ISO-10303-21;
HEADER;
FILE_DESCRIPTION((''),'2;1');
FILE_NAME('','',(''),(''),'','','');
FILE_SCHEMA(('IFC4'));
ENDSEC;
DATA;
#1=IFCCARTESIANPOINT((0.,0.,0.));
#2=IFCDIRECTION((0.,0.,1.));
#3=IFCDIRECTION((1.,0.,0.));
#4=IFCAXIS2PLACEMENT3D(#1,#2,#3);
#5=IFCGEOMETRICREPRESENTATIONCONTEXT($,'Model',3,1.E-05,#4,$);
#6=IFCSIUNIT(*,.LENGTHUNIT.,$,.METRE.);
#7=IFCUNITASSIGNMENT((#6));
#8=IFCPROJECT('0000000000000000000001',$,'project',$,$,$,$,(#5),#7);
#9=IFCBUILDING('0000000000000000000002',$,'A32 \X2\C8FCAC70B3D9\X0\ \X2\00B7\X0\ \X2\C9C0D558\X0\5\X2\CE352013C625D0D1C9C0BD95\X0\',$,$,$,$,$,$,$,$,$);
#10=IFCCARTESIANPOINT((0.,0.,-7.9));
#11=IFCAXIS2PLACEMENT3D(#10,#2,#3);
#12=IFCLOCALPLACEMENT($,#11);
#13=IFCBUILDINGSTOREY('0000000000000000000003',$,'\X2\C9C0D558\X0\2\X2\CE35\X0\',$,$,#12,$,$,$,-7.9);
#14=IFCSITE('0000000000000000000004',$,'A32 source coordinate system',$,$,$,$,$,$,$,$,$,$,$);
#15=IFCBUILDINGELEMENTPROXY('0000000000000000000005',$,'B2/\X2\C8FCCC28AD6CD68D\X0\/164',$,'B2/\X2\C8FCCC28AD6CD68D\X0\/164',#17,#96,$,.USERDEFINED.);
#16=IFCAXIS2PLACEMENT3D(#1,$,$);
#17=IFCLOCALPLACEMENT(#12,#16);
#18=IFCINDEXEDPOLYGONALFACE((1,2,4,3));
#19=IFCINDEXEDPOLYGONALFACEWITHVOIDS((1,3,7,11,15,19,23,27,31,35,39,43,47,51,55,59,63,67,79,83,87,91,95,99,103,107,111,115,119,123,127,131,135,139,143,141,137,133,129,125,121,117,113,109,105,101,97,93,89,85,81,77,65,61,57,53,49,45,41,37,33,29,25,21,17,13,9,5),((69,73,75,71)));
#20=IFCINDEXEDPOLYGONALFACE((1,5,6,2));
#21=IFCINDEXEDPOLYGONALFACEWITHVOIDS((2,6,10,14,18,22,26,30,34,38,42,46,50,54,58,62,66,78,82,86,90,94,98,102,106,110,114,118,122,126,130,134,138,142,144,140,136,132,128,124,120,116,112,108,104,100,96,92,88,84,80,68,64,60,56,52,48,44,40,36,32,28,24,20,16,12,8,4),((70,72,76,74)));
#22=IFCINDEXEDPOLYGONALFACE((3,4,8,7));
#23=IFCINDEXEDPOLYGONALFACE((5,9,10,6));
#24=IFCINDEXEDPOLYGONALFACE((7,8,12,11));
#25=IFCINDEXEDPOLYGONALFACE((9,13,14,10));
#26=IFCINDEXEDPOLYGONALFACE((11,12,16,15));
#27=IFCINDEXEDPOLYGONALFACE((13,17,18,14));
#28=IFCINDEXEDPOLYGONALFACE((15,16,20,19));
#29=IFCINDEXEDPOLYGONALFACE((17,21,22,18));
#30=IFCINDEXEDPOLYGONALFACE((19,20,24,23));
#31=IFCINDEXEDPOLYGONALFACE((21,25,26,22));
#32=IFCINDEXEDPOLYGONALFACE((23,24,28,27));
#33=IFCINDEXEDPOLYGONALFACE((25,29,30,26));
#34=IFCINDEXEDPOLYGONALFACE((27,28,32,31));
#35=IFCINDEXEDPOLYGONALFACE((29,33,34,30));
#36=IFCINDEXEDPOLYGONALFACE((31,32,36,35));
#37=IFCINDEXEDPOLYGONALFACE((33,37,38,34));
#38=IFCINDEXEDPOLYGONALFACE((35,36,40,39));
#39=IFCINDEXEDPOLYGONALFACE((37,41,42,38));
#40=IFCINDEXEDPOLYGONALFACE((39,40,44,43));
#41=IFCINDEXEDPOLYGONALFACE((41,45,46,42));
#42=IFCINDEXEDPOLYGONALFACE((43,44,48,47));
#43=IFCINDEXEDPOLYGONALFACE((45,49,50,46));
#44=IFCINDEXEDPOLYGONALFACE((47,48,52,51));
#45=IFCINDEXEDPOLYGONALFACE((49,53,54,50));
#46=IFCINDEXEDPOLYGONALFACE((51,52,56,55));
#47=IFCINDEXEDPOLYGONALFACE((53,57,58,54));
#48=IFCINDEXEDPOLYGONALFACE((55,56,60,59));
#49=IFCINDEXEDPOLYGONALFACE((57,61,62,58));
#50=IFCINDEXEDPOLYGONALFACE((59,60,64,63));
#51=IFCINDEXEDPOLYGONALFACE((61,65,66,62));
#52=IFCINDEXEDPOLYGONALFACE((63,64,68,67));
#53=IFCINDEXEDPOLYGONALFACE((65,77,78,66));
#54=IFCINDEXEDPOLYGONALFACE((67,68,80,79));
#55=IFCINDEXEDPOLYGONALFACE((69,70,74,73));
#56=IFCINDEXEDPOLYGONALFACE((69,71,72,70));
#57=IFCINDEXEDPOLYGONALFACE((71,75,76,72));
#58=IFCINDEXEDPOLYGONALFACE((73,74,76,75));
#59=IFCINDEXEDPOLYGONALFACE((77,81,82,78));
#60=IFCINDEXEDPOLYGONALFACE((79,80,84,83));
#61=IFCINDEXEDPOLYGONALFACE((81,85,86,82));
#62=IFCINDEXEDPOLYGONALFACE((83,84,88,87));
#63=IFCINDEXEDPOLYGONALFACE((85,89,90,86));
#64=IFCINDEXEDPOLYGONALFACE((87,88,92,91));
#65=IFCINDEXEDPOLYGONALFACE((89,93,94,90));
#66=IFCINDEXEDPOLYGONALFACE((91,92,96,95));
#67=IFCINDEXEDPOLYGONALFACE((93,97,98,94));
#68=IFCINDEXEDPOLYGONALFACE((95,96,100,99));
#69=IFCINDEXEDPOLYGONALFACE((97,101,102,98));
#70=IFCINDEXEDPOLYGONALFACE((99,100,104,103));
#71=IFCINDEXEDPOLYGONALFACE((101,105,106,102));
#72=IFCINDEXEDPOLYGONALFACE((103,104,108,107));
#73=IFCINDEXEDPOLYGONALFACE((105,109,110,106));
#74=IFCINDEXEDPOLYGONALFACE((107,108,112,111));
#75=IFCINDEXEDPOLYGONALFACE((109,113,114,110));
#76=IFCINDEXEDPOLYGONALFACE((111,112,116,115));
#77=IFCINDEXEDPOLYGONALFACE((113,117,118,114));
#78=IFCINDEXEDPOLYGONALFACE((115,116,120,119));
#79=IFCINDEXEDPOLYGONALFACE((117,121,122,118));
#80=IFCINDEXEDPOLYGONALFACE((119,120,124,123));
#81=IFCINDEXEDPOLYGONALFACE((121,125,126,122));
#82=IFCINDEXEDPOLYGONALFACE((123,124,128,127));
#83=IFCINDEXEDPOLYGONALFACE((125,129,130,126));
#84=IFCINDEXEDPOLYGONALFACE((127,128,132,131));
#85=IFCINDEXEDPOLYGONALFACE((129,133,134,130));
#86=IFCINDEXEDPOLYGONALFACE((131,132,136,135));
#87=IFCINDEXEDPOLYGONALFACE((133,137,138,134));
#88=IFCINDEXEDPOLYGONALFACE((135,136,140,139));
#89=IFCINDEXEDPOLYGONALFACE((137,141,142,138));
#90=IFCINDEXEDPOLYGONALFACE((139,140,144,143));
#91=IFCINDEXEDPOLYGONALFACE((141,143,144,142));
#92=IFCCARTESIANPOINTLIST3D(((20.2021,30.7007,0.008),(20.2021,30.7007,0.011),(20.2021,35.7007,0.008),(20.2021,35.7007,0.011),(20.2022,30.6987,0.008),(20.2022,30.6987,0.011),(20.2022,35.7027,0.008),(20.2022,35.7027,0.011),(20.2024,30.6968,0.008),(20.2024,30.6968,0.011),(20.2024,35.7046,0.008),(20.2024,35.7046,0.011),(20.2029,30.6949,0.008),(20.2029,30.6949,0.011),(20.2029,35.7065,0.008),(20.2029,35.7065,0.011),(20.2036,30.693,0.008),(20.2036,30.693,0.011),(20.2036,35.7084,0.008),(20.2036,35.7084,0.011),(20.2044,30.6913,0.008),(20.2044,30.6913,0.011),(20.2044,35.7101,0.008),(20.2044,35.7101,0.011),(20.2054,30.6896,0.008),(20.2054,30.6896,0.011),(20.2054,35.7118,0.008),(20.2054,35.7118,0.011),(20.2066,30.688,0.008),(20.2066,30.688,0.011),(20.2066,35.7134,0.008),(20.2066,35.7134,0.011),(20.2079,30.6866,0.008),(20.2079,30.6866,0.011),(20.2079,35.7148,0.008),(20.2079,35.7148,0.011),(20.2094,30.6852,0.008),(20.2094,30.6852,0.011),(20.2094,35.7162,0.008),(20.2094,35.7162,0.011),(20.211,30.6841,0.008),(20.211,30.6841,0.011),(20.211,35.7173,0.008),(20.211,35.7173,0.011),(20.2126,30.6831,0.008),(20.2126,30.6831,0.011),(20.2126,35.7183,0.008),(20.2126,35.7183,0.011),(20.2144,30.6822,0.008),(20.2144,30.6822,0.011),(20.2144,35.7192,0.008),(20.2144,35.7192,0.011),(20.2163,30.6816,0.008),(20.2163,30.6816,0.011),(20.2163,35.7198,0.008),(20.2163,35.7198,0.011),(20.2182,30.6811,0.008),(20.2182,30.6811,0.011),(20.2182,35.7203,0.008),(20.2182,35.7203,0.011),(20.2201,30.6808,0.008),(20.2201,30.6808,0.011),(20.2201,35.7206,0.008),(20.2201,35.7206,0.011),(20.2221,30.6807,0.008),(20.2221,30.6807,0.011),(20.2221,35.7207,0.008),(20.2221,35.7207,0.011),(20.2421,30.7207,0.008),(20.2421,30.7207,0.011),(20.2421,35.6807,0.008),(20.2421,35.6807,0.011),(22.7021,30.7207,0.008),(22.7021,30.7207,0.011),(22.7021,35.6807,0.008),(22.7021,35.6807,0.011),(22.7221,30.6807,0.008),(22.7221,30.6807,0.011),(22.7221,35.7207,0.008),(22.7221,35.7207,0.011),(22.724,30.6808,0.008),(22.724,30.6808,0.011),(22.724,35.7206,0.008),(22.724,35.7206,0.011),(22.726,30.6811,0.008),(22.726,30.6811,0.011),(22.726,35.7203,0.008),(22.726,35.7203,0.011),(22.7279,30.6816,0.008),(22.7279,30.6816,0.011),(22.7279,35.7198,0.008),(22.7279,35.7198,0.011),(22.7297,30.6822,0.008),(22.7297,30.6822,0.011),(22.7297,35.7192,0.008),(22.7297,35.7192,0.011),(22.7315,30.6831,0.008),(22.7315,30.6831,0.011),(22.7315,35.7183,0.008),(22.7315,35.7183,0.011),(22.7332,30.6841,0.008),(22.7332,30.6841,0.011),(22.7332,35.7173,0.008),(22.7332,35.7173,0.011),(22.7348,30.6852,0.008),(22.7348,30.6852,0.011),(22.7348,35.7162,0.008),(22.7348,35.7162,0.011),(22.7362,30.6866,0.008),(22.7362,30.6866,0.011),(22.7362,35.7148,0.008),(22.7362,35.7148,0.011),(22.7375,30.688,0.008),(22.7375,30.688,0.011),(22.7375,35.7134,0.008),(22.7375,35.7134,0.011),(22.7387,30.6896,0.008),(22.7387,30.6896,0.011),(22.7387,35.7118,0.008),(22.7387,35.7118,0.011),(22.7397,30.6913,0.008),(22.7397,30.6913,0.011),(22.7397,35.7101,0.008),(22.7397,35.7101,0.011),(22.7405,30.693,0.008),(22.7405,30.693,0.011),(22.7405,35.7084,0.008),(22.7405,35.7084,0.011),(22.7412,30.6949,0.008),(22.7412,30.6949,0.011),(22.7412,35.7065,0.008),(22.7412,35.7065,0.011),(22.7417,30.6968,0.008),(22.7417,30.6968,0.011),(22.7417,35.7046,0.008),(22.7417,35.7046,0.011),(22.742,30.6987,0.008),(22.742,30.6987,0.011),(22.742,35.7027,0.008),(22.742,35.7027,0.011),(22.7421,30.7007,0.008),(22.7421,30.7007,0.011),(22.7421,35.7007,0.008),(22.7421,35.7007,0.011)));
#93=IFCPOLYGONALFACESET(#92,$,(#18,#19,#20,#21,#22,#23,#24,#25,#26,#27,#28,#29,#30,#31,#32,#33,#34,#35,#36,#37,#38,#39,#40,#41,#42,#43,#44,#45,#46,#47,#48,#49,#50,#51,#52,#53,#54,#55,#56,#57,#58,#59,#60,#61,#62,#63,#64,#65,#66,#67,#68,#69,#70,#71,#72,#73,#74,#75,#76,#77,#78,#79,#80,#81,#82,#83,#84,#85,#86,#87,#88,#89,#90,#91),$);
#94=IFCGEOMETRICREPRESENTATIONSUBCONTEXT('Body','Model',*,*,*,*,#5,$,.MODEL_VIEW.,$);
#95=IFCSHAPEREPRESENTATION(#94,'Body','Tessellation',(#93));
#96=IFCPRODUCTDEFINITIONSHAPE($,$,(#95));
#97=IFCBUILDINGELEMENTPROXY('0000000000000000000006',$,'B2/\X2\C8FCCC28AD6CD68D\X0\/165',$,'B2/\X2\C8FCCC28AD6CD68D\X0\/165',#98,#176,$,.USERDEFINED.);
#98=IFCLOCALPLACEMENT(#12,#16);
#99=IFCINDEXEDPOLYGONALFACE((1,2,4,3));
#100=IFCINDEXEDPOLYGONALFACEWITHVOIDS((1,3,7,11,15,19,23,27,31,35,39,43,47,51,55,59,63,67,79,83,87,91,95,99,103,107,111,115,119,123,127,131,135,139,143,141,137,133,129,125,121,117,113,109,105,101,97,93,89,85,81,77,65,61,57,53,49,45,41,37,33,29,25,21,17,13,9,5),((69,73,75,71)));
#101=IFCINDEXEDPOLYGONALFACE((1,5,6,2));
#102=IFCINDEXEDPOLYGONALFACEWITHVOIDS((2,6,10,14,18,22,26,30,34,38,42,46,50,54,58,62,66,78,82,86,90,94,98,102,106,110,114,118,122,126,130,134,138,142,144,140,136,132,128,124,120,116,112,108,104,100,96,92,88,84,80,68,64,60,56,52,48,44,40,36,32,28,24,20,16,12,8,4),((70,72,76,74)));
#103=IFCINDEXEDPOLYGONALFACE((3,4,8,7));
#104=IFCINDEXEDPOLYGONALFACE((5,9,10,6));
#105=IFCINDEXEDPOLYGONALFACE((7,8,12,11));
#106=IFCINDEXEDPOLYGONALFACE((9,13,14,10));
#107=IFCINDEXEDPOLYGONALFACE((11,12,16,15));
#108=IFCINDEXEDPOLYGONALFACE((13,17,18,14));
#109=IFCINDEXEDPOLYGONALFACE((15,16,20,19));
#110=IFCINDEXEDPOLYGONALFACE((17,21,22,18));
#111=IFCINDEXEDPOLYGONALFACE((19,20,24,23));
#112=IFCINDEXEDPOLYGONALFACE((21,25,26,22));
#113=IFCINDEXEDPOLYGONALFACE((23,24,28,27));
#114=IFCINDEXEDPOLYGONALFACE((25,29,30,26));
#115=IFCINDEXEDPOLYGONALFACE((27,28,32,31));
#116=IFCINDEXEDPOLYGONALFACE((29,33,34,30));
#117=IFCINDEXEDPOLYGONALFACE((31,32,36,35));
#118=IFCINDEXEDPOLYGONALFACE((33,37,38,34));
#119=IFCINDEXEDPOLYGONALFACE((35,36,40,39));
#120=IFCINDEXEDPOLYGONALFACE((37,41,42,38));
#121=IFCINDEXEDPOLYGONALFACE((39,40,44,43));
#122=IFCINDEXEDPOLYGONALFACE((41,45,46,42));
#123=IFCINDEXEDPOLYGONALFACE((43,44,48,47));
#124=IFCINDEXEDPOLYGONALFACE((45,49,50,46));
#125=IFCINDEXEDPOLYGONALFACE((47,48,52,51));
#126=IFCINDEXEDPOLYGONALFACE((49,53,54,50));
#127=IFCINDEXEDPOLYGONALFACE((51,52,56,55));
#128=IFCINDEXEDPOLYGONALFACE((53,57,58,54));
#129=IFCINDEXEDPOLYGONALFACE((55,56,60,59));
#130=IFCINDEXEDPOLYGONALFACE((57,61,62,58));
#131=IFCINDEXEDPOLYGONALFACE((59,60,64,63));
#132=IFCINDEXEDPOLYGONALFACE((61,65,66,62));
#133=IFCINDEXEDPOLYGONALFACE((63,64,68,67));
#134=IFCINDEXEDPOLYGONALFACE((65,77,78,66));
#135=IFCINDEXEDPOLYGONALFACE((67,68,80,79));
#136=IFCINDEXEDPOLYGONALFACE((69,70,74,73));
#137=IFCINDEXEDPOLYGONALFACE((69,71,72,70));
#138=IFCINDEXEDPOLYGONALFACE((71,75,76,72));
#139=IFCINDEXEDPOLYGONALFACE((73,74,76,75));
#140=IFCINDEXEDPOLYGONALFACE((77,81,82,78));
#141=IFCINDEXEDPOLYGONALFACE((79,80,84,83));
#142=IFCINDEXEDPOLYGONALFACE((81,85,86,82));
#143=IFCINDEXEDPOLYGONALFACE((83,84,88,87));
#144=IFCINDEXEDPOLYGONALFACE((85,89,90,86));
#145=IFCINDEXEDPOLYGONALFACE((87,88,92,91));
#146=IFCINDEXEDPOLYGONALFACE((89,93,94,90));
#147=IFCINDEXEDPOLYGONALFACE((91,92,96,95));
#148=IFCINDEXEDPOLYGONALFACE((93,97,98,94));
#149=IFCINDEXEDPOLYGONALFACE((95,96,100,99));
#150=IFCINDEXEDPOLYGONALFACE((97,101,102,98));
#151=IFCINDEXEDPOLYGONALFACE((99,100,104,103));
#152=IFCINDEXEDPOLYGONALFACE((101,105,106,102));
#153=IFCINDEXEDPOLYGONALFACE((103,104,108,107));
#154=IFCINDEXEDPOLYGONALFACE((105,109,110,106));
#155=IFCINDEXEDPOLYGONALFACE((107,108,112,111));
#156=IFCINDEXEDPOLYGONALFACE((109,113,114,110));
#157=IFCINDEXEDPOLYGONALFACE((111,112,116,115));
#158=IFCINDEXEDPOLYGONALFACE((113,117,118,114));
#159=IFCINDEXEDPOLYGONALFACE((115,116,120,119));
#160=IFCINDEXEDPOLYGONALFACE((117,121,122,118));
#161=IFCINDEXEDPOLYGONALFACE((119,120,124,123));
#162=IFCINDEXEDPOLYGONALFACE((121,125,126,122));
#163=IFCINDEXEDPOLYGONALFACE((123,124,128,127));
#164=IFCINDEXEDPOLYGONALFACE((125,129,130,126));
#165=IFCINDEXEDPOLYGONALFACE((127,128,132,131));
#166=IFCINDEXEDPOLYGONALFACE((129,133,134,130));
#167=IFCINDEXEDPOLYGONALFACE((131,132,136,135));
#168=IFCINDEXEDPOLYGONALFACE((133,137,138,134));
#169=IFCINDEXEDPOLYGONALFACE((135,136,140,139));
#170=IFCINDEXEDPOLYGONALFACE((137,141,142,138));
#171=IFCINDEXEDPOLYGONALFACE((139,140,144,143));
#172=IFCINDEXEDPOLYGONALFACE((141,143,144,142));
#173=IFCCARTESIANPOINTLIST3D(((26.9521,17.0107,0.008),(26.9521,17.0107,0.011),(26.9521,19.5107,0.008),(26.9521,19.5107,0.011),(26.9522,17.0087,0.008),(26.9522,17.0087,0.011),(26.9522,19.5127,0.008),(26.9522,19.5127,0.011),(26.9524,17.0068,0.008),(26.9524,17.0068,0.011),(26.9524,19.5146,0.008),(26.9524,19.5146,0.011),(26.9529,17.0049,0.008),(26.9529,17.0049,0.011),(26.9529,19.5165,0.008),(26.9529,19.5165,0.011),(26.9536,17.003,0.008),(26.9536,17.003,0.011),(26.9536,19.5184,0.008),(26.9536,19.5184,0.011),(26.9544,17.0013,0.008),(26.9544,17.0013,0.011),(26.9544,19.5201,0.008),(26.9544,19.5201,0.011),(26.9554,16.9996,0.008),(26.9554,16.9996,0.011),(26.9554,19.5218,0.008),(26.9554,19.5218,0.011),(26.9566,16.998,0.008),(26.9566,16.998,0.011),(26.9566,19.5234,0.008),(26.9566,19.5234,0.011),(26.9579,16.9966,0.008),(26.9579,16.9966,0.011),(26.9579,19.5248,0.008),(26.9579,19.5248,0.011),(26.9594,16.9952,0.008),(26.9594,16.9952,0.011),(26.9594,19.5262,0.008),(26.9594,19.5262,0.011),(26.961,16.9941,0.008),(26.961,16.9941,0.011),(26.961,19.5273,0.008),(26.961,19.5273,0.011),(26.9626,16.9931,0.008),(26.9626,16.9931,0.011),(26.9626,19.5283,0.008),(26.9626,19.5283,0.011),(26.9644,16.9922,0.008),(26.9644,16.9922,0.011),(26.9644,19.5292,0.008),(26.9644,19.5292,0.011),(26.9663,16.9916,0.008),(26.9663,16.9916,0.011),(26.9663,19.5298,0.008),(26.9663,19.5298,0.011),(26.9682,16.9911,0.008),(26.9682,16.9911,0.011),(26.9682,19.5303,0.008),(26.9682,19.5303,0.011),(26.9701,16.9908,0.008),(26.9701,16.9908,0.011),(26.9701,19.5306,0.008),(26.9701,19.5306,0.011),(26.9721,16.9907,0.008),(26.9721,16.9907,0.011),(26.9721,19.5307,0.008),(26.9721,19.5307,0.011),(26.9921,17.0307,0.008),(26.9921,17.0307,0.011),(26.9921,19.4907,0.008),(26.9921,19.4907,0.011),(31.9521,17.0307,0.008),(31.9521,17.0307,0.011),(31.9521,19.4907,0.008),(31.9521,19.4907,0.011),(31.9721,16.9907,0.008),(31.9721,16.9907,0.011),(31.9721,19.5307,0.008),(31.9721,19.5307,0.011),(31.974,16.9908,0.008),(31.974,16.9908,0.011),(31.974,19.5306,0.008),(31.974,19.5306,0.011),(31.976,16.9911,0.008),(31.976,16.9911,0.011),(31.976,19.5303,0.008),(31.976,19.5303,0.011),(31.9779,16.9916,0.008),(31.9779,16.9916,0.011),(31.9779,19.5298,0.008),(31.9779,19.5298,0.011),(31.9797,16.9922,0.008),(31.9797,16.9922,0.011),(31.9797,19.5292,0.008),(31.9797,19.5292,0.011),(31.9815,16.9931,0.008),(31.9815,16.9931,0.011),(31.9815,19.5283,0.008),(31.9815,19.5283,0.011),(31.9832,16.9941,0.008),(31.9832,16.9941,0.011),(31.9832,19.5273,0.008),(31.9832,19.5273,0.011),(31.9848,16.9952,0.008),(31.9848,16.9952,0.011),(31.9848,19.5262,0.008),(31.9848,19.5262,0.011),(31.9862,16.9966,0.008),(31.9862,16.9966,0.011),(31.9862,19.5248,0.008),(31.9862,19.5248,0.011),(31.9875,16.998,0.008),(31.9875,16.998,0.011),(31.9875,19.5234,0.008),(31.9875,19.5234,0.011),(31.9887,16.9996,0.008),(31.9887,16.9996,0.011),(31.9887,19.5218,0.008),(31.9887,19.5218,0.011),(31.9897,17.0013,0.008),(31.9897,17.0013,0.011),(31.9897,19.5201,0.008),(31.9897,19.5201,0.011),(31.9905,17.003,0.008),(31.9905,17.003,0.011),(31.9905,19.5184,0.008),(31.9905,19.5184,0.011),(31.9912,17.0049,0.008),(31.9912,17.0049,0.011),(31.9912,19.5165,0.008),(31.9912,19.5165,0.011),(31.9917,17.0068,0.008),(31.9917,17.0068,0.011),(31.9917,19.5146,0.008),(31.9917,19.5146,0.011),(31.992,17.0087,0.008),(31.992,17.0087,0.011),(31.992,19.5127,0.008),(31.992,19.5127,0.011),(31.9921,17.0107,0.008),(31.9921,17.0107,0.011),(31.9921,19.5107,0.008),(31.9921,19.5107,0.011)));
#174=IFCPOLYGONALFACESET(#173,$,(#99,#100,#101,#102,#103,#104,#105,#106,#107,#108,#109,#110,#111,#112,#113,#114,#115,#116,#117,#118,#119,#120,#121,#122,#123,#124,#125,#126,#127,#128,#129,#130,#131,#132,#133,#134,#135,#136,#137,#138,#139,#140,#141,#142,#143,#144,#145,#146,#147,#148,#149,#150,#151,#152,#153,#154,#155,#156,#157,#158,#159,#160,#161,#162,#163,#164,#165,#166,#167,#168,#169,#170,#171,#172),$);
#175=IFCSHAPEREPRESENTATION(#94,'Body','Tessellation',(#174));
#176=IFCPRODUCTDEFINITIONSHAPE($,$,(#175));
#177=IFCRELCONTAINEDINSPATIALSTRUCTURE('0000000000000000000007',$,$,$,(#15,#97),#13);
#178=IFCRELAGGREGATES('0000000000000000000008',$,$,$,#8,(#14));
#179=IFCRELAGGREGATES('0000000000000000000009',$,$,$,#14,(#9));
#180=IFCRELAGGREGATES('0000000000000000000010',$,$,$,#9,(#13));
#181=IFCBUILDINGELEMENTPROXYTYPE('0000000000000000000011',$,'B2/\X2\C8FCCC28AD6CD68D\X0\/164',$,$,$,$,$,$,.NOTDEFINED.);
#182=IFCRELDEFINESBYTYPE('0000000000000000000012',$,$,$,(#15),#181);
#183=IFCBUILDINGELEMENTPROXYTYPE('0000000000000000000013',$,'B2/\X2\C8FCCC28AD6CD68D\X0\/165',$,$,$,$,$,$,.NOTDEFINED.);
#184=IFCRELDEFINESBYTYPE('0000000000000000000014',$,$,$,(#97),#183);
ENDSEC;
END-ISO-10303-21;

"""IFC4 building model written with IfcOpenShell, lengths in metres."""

from ifc_helpers import new_model, si_unit, frame, origin, origin_with_axes, place, context, subcontext, project, spatial, polyline, outline, extrude, source, transform, mapped, type_object, type_shapes, element, save


model = new_model("IFC4")

# Units and contexts
model_context = context("Model", 3, precision=1e-05, world=origin_with_axes())
body_context = subcontext(model_context, "Body", "Model", "MODEL_VIEW")
ifc_project = project(units=[si_unit("LENGTHUNIT", "METRE")], contexts=[model_context])

# Site, building, storey
site = spatial("IfcSite", under=ifc_project, Name="A32 source coordinate system")
building = spatial("IfcBuilding", under=site, Name="A32 주거동 · 지하5층–옥탑지붕")
storey_placement = place(None, frame((0.0, 0.0, -7.9), z_axis=(0.0, 0.0, 1.0), x_axis=(1.0, 0.0, 0.0)))
storey = spatial("IfcBuildingStorey", under=building, at=storey_placement, Name="지하2층", Elevation=-7.9)

# Building element proxies
building_element_proxy_type_1 = type_object("IfcBuildingElementProxyType", Name="B2/주차구획/164", PredefinedType="NOTDEFINED")
shared_shape_1 = source(origin(), body_context, "Body", "SweptSolid", [
    extrude(outline(polyline([(20.2021, 35.7007), (20.2022, 35.7027), (20.2024, 35.7046), (20.2029, 35.7065), (20.2036, 35.7084), (20.2044, 35.7101), (20.2054, 35.7118), (20.2066, 35.7134), (20.2079, 35.7148), (20.2094, 35.7162), (20.211, 35.7173), (20.2126, 35.7183), (20.2144, 35.7192), (20.2163, 35.7198), (20.2182, 35.7203), (20.2201, 35.7206), (20.2221, 35.7207), (22.7221, 35.7207), (22.724, 35.7206), (22.726, 35.7203), (22.7279, 35.7198), (22.7297, 35.7192), (22.7315, 35.7183), (22.7332, 35.7173), (22.7348, 35.7162), (22.7362, 35.7148), (22.7375, 35.7134), (22.7387, 35.7118), (22.7397, 35.7101), (22.7405, 35.7084), (22.7412, 35.7065), (22.7417, 35.7046), (22.742, 35.7027), (22.7421, 35.7007), (22.7421, 30.7007), (22.742, 30.6987), (22.7417, 30.6968), (22.7412, 30.6949), (22.7405, 30.693), (22.7397, 30.6913), (22.7387, 30.6896), (22.7375, 30.688), (22.7362, 30.6866), (22.7348, 30.6852), (22.7332, 30.6841), (22.7315, 30.6831), (22.7297, 30.6822), (22.7279, 30.6816), (22.726, 30.6811), (22.724, 30.6808), (22.7221, 30.6807), (20.2221, 30.6807), (20.2201, 30.6808), (20.2182, 30.6811), (20.2163, 30.6816), (20.2144, 30.6822), (20.2126, 30.6831), (20.211, 30.6841), (20.2094, 30.6852), (20.2079, 30.6866), (20.2066, 30.688), (20.2054, 30.6896), (20.2044, 30.6913), (20.2036, 30.693), (20.2029, 30.6949), (20.2024, 30.6968), (20.2022, 30.6987), (20.2021, 30.7007), (20.2021, 35.7007)]), holes=[polyline([(20.2421, 35.6807), (20.2421, 30.7207), (22.7021, 30.7207), (22.7021, 35.6807), (20.2421, 35.6807)])]), frame((0.0, 0.0, 0.008)), (0.0, 0.0, 1.0), 0.003),
])
type_shapes(building_element_proxy_type_1, [shared_shape_1])
proxy_1_placement = place(storey_placement, origin_with_axes())
element("IfcBuildingElementProxy", 1, at=proxy_1_placement, inside=storey, type_object=building_element_proxy_type_1, Name="B2/주차구획/164", ObjectType="B2/주차구획/164", PredefinedType="USERDEFINED", context=body_context, shape_type="MappedRepresentation", body=[
    mapped(shared_shape_1, transform((0.0, 0.0, 0.0), scale=1.0)),
])
building_element_proxy_type_2 = type_object("IfcBuildingElementProxyType", Name="B2/주차구획/165", PredefinedType="NOTDEFINED")
shared_shape_2 = source(origin(), body_context, "Body", "SweptSolid", [
    extrude(outline(polyline([(26.9721, 16.9907), (26.9701, 16.9908), (26.9682, 16.9911), (26.9663, 16.9916), (26.9644, 16.9922), (26.9626, 16.9931), (26.961, 16.9941), (26.9594, 16.9952), (26.9579, 16.9966), (26.9566, 16.998), (26.9554, 16.9996), (26.9544, 17.0013), (26.9536, 17.003), (26.9529, 17.0049), (26.9524, 17.0068), (26.9522, 17.0087), (26.9521, 17.0107), (26.9521, 19.5107), (26.9522, 19.5127), (26.9524, 19.5146), (26.9529, 19.5165), (26.9536, 19.5184), (26.9544, 19.5201), (26.9554, 19.5218), (26.9566, 19.5234), (26.9579, 19.5248), (26.9594, 19.5262), (26.961, 19.5273), (26.9626, 19.5283), (26.9644, 19.5292), (26.9663, 19.5298), (26.9682, 19.5303), (26.9701, 19.5306), (26.9721, 19.5307), (31.9721, 19.5307), (31.974, 19.5306), (31.976, 19.5303), (31.9779, 19.5298), (31.9797, 19.5292), (31.9815, 19.5283), (31.9832, 19.5273), (31.9848, 19.5262), (31.9862, 19.5248), (31.9875, 19.5234), (31.9887, 19.5218), (31.9897, 19.5201), (31.9905, 19.5184), (31.9912, 19.5165), (31.9917, 19.5146), (31.992, 19.5127), (31.9921, 19.5107), (31.9921, 17.0107), (31.992, 17.0087), (31.9917, 17.0068), (31.9912, 17.0049), (31.9905, 17.003), (31.9897, 17.0013), (31.9887, 16.9996), (31.9875, 16.998), (31.9862, 16.9966), (31.9848, 16.9952), (31.9832, 16.9941), (31.9815, 16.9931), (31.9797, 16.9922), (31.9779, 16.9916), (31.976, 16.9911), (31.974, 16.9908), (31.9721, 16.9907), (26.9721, 16.9907)]), holes=[polyline([(26.9921, 17.0307), (31.9521, 17.0307), (31.9521, 19.4907), (26.9921, 19.4907), (26.9921, 17.0307)])]), frame((0.0, 0.0, 0.008)), (0.0, 0.0, 1.0), 0.003),
])
type_shapes(building_element_proxy_type_2, [shared_shape_2])
proxy_2_placement = place(storey_placement, origin_with_axes())
element("IfcBuildingElementProxy", 2, at=proxy_2_placement, inside=storey, type_object=building_element_proxy_type_2, Name="B2/주차구획/165", ObjectType="B2/주차구획/165", PredefinedType="USERDEFINED", context=body_context, shape_type="MappedRepresentation", body=[
    mapped(shared_shape_2, transform((0.0, 0.0, 0.0), scale=1.0)),
])

save(model, "model.ifc")
